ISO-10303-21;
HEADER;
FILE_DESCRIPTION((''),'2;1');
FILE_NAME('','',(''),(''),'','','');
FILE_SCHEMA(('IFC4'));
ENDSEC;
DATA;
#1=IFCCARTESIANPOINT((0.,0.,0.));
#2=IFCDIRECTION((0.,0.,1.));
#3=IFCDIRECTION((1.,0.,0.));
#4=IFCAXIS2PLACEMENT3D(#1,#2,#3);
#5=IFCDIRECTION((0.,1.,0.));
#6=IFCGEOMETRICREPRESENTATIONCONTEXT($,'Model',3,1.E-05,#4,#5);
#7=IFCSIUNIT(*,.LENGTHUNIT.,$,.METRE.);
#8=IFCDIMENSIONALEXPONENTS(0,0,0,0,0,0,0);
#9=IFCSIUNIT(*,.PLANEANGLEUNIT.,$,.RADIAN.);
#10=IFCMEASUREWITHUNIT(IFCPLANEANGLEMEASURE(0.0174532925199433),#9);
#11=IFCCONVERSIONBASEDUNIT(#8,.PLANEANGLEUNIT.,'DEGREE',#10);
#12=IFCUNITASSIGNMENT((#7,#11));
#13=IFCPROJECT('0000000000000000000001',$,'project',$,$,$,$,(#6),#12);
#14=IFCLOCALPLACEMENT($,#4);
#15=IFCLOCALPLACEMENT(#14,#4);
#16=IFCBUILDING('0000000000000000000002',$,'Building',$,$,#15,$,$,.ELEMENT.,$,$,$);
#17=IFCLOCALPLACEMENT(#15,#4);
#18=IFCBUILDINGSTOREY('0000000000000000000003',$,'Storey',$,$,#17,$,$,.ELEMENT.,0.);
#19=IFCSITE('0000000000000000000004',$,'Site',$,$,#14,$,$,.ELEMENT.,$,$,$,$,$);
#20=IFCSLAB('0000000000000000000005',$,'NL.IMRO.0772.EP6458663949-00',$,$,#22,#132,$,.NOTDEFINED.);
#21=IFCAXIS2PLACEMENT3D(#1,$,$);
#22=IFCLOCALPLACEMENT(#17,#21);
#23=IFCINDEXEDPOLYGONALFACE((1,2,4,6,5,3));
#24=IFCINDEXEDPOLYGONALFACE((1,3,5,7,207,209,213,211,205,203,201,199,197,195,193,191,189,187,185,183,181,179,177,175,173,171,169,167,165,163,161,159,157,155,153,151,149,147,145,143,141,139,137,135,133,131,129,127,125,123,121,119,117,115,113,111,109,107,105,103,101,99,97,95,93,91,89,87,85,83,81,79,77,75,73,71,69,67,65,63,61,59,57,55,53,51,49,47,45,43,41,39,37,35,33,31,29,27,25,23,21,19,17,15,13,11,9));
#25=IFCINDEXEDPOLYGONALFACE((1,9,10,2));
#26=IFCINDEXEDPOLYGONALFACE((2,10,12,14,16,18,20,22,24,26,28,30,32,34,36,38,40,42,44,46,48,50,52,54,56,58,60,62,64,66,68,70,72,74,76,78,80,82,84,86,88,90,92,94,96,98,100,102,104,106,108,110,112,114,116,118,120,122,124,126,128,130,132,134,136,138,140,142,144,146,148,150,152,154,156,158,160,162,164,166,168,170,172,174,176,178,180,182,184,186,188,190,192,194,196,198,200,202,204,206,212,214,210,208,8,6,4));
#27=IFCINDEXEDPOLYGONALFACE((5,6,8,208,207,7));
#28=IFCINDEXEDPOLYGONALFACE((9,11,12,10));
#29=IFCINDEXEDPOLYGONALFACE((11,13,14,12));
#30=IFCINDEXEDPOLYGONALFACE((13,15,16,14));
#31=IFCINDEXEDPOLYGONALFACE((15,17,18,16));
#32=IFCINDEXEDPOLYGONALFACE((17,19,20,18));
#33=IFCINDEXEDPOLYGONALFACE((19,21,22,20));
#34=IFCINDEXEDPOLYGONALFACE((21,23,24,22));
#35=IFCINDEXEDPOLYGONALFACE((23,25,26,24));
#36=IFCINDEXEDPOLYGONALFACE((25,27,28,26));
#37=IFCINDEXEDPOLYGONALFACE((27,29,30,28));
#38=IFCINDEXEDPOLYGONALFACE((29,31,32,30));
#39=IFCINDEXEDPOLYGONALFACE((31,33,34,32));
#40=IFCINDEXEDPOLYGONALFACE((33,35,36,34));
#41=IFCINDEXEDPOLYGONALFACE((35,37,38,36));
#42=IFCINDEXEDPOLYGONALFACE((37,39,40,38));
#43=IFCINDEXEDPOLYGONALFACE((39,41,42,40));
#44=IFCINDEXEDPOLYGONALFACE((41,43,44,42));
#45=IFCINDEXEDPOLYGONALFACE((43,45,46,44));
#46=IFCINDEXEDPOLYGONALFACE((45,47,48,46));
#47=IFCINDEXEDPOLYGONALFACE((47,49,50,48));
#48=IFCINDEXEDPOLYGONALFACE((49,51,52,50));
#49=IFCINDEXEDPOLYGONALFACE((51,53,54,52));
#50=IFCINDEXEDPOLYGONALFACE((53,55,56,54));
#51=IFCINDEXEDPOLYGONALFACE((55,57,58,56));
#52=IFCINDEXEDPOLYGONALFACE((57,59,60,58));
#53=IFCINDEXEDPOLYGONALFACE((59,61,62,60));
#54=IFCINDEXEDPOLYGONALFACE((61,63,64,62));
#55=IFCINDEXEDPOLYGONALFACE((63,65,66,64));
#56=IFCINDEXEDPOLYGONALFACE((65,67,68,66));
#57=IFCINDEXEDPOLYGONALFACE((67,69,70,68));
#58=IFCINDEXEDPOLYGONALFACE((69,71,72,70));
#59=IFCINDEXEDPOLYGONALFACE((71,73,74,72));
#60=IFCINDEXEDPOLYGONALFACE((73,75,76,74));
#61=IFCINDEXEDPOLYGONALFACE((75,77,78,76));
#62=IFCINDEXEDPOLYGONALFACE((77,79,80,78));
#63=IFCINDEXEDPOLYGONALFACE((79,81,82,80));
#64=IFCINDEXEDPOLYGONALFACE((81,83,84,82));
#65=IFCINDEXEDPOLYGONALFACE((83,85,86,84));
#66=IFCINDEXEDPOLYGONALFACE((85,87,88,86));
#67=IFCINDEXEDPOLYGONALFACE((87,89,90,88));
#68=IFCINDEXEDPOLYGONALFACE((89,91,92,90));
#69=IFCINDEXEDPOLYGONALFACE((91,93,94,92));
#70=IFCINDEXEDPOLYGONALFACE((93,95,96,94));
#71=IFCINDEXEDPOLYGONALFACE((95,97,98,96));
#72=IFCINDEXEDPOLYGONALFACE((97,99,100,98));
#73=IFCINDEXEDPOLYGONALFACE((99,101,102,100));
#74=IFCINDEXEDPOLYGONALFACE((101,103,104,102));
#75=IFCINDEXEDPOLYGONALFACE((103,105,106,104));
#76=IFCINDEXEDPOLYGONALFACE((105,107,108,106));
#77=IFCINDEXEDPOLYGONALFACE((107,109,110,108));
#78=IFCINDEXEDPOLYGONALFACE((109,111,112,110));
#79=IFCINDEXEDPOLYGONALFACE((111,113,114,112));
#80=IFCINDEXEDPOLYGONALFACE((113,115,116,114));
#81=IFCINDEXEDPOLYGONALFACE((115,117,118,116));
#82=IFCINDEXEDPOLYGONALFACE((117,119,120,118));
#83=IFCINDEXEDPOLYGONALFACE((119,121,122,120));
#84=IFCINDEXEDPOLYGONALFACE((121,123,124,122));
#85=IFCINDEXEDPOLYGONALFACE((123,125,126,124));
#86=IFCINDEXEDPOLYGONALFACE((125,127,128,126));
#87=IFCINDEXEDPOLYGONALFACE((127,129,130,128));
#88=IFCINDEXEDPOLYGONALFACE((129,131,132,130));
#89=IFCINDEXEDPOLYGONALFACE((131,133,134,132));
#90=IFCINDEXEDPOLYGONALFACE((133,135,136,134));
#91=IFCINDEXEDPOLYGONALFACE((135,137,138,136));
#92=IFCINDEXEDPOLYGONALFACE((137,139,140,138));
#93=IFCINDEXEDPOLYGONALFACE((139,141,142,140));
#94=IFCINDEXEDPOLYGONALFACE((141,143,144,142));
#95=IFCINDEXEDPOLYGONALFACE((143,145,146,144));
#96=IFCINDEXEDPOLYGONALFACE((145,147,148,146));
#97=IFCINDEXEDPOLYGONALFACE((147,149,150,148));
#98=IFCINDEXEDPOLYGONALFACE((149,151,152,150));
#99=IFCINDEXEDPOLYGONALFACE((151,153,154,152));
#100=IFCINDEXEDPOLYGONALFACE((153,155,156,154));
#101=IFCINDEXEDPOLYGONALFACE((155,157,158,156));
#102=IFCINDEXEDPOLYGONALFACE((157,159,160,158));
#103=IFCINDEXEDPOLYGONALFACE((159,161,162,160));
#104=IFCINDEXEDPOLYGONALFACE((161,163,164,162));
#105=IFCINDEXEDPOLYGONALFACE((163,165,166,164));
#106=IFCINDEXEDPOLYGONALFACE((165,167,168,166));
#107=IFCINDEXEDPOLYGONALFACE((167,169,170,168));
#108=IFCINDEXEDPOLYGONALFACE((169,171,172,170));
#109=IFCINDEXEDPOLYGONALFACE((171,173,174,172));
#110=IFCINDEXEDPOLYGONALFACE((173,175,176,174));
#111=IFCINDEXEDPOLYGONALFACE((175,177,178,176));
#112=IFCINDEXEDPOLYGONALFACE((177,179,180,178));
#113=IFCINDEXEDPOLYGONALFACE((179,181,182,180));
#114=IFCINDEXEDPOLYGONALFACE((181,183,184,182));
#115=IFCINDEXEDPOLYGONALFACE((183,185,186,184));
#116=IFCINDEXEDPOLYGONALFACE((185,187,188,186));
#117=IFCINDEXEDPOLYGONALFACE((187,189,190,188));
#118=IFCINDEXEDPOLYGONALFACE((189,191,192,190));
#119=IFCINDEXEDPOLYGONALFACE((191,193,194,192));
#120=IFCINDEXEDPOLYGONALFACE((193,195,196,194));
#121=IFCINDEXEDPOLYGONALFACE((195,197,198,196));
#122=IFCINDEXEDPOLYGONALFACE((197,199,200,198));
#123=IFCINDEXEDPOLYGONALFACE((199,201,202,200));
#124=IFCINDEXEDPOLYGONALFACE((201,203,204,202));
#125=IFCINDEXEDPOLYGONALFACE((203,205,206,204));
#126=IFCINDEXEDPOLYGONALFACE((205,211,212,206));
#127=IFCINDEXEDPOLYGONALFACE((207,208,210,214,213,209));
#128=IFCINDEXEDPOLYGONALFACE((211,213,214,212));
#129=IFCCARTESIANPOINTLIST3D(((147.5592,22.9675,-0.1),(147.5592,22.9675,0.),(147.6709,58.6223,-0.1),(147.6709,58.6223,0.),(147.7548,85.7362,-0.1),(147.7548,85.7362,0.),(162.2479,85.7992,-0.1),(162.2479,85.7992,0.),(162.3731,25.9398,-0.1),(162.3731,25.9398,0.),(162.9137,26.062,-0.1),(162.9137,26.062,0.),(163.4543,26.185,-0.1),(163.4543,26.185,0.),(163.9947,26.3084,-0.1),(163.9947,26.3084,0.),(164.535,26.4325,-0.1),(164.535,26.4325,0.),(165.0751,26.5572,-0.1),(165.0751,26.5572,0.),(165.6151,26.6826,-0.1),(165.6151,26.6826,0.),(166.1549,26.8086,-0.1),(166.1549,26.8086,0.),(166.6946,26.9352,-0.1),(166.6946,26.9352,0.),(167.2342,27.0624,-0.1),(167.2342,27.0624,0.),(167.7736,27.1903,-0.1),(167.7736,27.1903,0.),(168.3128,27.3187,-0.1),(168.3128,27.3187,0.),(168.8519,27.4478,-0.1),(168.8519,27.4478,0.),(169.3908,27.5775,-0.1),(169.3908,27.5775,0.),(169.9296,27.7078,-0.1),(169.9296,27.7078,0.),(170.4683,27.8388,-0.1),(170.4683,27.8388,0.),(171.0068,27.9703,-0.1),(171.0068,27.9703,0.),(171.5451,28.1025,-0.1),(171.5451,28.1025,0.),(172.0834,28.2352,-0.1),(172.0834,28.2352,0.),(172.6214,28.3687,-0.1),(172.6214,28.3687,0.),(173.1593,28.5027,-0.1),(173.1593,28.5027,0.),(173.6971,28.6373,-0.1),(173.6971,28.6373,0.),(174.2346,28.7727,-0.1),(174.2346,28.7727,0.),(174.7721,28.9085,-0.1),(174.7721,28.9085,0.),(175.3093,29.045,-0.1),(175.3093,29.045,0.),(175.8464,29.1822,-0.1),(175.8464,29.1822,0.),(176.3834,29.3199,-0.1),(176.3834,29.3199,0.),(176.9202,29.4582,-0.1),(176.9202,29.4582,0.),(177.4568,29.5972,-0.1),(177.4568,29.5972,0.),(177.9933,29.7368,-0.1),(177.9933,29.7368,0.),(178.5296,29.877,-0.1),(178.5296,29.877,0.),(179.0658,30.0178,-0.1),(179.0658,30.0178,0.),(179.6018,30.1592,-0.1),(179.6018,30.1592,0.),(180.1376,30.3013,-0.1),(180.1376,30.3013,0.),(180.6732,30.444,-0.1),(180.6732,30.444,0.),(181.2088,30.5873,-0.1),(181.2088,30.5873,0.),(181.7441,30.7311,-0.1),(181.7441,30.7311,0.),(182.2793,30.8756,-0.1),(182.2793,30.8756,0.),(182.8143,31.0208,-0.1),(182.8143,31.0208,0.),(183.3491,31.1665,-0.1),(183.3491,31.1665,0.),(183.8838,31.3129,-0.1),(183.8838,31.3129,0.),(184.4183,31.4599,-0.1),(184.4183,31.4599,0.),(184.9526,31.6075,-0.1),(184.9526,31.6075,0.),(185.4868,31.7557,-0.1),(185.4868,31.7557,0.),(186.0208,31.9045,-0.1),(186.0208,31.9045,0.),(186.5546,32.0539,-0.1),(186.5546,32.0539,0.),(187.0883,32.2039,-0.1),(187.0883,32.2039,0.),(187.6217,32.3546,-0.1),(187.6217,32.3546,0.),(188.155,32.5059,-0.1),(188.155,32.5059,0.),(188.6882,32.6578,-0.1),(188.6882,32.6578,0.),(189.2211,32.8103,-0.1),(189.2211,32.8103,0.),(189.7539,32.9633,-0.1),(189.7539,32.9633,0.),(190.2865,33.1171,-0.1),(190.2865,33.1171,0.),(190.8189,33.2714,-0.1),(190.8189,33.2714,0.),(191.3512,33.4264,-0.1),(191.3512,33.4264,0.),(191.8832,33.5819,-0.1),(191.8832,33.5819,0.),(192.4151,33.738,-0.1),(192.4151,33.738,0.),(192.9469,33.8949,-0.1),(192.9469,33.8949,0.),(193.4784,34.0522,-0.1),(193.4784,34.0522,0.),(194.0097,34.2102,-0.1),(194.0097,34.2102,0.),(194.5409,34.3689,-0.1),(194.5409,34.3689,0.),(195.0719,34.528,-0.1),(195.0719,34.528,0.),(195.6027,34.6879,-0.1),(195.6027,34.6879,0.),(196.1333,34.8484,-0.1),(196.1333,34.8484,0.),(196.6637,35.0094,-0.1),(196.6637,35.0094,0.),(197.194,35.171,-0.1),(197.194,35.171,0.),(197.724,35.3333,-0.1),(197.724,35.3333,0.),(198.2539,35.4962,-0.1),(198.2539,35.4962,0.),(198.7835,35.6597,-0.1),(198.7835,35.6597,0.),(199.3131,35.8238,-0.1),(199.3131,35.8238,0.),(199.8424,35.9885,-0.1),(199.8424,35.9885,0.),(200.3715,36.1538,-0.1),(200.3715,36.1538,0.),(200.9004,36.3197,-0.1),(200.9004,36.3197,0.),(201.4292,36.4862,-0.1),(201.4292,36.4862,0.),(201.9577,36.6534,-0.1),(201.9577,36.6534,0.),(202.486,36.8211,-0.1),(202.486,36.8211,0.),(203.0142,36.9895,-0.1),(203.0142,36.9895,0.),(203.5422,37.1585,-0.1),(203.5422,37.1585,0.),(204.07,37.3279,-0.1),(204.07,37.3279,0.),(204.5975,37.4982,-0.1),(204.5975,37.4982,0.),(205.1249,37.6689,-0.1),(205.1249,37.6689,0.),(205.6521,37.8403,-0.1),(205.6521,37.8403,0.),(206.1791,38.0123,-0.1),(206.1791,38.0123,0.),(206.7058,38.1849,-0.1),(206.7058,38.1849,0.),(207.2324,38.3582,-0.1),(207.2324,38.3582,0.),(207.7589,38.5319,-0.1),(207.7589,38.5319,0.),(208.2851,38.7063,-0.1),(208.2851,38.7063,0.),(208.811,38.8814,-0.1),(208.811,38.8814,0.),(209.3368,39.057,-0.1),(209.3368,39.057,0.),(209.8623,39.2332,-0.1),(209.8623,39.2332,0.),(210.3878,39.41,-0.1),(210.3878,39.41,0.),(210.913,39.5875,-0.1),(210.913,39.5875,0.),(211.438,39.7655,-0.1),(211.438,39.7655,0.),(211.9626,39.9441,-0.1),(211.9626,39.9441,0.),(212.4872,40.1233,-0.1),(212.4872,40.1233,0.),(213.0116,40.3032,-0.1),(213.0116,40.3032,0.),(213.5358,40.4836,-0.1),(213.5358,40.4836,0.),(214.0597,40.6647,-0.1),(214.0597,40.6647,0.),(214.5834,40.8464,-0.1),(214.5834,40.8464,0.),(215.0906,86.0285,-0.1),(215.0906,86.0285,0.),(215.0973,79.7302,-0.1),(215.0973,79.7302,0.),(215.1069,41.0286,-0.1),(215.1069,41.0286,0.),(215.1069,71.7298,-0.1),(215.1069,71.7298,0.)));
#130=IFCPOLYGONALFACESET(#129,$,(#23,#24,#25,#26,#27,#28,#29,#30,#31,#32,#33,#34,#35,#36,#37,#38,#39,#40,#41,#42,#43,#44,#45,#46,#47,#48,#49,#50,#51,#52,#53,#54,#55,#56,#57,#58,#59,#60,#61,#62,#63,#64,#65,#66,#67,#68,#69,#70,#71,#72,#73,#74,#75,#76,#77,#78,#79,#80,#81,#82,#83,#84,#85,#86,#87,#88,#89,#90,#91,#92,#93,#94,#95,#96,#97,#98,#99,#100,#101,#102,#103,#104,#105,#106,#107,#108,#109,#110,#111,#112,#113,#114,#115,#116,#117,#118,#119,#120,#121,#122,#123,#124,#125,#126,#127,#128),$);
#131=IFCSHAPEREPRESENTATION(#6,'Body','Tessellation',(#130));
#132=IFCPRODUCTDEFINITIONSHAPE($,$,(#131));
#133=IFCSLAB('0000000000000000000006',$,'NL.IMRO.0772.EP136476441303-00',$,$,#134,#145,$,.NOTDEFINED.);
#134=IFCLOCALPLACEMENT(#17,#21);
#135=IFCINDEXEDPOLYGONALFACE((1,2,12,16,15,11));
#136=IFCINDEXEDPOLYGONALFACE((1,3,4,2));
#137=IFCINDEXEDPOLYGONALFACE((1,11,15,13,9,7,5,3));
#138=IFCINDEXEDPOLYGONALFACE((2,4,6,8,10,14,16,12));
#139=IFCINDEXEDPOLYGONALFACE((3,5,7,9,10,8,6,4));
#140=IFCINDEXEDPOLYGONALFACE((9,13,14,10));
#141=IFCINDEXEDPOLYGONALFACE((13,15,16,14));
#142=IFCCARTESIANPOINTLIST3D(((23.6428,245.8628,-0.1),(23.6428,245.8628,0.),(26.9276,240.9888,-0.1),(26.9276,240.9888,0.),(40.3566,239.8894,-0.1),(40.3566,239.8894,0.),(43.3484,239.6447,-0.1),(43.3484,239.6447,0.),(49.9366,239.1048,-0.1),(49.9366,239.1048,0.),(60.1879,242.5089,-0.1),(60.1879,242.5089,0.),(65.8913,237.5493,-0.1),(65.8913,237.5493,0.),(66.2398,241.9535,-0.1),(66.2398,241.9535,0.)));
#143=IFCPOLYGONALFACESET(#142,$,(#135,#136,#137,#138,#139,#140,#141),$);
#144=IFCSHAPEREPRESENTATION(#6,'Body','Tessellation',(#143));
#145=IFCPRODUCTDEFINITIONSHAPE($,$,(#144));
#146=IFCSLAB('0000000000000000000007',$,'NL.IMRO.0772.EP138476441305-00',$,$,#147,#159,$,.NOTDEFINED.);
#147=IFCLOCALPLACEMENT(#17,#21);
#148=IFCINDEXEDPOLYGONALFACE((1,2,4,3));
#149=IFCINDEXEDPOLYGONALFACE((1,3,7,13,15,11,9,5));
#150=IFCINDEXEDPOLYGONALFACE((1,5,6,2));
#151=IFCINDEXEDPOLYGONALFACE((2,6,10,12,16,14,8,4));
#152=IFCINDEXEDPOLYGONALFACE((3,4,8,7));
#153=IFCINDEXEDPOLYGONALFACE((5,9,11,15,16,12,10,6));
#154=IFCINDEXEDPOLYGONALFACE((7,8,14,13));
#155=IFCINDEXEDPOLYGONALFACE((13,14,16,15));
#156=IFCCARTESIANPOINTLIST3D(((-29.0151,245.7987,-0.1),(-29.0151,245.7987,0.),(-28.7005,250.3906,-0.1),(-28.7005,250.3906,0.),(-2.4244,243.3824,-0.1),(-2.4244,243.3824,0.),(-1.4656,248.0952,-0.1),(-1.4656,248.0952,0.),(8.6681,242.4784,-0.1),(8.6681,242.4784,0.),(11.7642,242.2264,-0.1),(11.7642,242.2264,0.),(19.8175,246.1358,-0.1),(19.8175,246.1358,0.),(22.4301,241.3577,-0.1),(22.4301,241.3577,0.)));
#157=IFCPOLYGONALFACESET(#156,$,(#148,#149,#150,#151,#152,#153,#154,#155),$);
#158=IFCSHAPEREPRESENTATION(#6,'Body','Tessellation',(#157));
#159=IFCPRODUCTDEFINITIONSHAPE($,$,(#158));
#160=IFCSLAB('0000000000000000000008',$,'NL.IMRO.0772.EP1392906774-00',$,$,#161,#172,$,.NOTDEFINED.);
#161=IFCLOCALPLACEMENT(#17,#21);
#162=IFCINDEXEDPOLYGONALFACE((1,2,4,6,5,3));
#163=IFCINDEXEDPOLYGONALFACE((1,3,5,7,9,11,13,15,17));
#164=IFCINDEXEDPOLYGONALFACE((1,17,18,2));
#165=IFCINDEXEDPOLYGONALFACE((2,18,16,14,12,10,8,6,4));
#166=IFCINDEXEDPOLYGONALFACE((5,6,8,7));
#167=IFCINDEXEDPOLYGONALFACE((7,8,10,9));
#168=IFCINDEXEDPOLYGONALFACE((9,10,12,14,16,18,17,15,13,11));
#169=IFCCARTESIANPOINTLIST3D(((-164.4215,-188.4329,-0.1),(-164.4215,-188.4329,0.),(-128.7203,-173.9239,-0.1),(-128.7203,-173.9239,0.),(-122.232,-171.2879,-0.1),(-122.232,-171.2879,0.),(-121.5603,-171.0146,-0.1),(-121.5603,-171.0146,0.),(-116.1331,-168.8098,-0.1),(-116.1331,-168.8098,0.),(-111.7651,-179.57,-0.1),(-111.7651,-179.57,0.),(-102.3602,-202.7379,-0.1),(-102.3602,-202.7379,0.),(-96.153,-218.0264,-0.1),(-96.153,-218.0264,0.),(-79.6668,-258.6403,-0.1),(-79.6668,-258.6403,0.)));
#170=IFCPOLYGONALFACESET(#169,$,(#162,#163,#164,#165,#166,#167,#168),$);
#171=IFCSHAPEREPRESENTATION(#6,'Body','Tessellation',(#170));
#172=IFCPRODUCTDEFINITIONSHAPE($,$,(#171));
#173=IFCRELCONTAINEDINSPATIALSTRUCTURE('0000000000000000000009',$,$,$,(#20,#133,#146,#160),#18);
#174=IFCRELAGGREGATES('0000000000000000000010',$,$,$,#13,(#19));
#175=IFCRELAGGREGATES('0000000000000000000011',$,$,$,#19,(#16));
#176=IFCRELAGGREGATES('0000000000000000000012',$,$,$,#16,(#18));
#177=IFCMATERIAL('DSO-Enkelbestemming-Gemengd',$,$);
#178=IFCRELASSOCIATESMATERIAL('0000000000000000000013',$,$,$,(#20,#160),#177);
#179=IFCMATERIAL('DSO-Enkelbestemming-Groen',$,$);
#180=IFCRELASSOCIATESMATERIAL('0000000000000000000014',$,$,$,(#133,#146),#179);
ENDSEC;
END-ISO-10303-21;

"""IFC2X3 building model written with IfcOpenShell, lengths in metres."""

from ifc_helpers import new_model, entity, si_unit, converted_unit, direction, frame, origin_with_axes, place, context, project, spatial, polyline, outline, extrude, material, element, save


model = new_model("IFC2X3")

# Units and contexts
model_context = context("Model", 3, precision=1e-05, world=origin_with_axes(), true_north=direction((0.0, 1.0, 0.0)))
ifc_project = project(units=[si_unit("LENGTHUNIT", "METRE"), converted_unit("PLANEANGLEUNIT", "DEGREE", entity("IfcPlaneAngleMeasure", 0.0174532925199433), si_unit("PLANEANGLEUNIT", "RADIAN"), dimensions=[0, 0, 0, 0, 0, 0, 0])], contexts=[model_context])

# Site, building, storey
site_placement = place(None, origin_with_axes())
site = spatial("IfcSite", under=ifc_project, at=site_placement, Name="Site", CompositionType="ELEMENT")
building_placement = place(site_placement, origin_with_axes())
building = spatial("IfcBuilding", under=site, at=building_placement, Name="Building", CompositionType="ELEMENT")
storey_placement = place(building_placement, origin_with_axes())
storey = spatial("IfcBuildingStorey", under=building, at=storey_placement, Name="Storey", CompositionType="ELEMENT", Elevation=0.0)

# Slabs
ifc_material_1 = material(Name="DSO-Enkelbestemming-Groen")
ifc_material_2 = material(Name="DSO-Enkelbestemming-Gemengd")
slab_1_placement = place(storey_placement, frame((0.0, 0.0, -0.1), z_axis=(0.0, 0.0, 1.0), x_axis=(1.0, 0.0, 0.0)))
element("IfcSlab", 1, at=slab_1_placement, inside=storey, material=ifc_material_2, Name="NL.IMRO.0772.EP6458663949-00", PredefinedType="NOTDEFINED", context=model_context, shape_type="SweptSolid", body=[
    extrude(outline(polyline([(147.5592, 22.9675), (147.6709, 58.6223), (147.7548, 85.7362), (162.2479, 85.7992), (215.0906, 86.0285), (215.0973, 79.7302), (215.1069, 71.7298), (215.1069, 41.0286), (214.5834, 40.8464), (214.0597, 40.6647), (213.5358, 40.4836), (213.0116, 40.3032), (212.4872, 40.1233), (211.9626, 39.9441), (211.438, 39.7655), (210.913, 39.5875), (210.3878, 39.41), (209.8623, 39.2332), (209.3368, 39.057), (208.811, 38.8814), (208.2851, 38.7063), (207.7589, 38.5319), (207.2324, 38.3582), (206.7058, 38.1849), (206.1791, 38.0123), (205.6521, 37.8403), (205.1249, 37.6689), (204.5975, 37.4982), (204.07, 37.3279), (203.5422, 37.1585), (203.0142, 36.9895), (202.486, 36.8211), (201.9577, 36.6534), (201.4292, 36.4862), (200.9004, 36.3197), (200.3715, 36.1538), (199.8424, 35.9885), (199.3131, 35.8238), (198.7835, 35.6597), (198.2539, 35.4962), (197.724, 35.3333), (197.194, 35.171), (196.6637, 35.0094), (196.1333, 34.8484), (195.6027, 34.6879), (195.0719, 34.528), (194.5409, 34.3689), (194.0097, 34.2102), (193.4784, 34.0522), (192.9469, 33.8949), (192.4151, 33.738), (191.8832, 33.5819), (191.3512, 33.4264), (190.8189, 33.2714), (190.2865, 33.1171), (189.7539, 32.9633), (189.2211, 32.8103), (188.6882, 32.6578), (188.155, 32.5059), (187.6217, 32.3546), (187.0883, 32.2039), (186.5546, 32.0539), (186.0208, 31.9045), (185.4868, 31.7557), (184.9526, 31.6075), (184.4183, 31.4599), (183.8838, 31.3129), (183.3491, 31.1665), (182.8143, 31.0208), (182.2793, 30.8756), (181.7441, 30.7311), (181.2088, 30.5873), (180.6732, 30.444), (180.1376, 30.3013), (179.6018, 30.1592), (179.0658, 30.0178), (178.5296, 29.877), (177.9933, 29.7368), (177.4568, 29.5972), (176.9202, 29.4582), (176.3834, 29.3199), (175.8464, 29.1822), (175.3093, 29.045), (174.7721, 28.9085), (174.2346, 28.7727), (173.6971, 28.6373), (173.1593, 28.5027), (172.6214, 28.3687), (172.0834, 28.2352), (171.5451, 28.1025), (171.0068, 27.9703), (170.4683, 27.8388), (169.9296, 27.7078), (169.3908, 27.5775), (168.8519, 27.4478), (168.3128, 27.3187), (167.7736, 27.1903), (167.2342, 27.0624), (166.6946, 26.9352), (166.1549, 26.8086), (165.6151, 26.6826), (165.0751, 26.5572), (164.535, 26.4325), (163.9947, 26.3084), (163.4543, 26.185), (162.9137, 26.062), (162.3731, 25.9398), (147.5592, 22.9675)])), origin_with_axes(), (0.0, 0.0, 1.0), 0.1),
])
slab_2_placement = place(storey_placement, frame((0.0, 0.0, -0.1), z_axis=(0.0, 0.0, 1.0), x_axis=(1.0, 0.0, 0.0)))
element("IfcSlab", 2, at=slab_2_placement, inside=storey, material=ifc_material_1, Name="NL.IMRO.0772.EP136476441303-00", PredefinedType="NOTDEFINED", context=model_context, shape_type="SweptSolid", body=[
    extrude(outline(polyline([(65.8913, 237.5493), (49.9366, 239.1048), (43.3484, 239.6447), (40.3566, 239.8894), (26.9276, 240.9888), (23.6428, 245.8628), (60.1879, 242.5089), (66.2398, 241.9535), (65.8913, 237.5493)])), origin_with_axes(), (0.0, 0.0, 1.0), 0.1),
])
slab_3_placement = place(storey_placement, frame((0.0, 0.0, -0.1), z_axis=(0.0, 0.0, 1.0), x_axis=(1.0, 0.0, 0.0)))
element("IfcSlab", 3, at=slab_3_placement, inside=storey, material=ifc_material_1, Name="NL.IMRO.0772.EP138476441305-00", PredefinedType="NOTDEFINED", context=model_context, shape_type="SweptSolid", body=[
    extrude(outline(polyline([(-2.4244, 243.3824), (-29.0151, 245.7987), (-28.7005, 250.3906), (-1.4656, 248.0952), (19.8175, 246.1358), (22.4301, 241.3577), (11.7642, 242.2264), (8.6681, 242.4784), (-2.4244, 243.3824)])), origin_with_axes(), (0.0, 0.0, 1.0), 0.1),
])
slab_4_placement = place(storey_placement, frame((0.0, 0.0, -0.1), z_axis=(0.0, 0.0, 1.0), x_axis=(1.0, 0.0, 0.0)))
element("IfcSlab", 4, at=slab_4_placement, inside=storey, material=ifc_material_2, Name="NL.IMRO.0772.EP1392906774-00", PredefinedType="NOTDEFINED", context=model_context, shape_type="SweptSolid", body=[
    extrude(outline(polyline([(-128.7203, -173.9239), (-122.232, -171.2879), (-121.5603, -171.0146), (-116.1331, -168.8098), (-111.7651, -179.57), (-102.3602, -202.7379), (-96.153, -218.0264), (-79.6668, -258.6403), (-164.4215, -188.4329), (-128.7203, -173.9239)])), origin_with_axes(), (0.0, 0.0, 1.0), 0.1),
])

save(model, "model.ifc")
